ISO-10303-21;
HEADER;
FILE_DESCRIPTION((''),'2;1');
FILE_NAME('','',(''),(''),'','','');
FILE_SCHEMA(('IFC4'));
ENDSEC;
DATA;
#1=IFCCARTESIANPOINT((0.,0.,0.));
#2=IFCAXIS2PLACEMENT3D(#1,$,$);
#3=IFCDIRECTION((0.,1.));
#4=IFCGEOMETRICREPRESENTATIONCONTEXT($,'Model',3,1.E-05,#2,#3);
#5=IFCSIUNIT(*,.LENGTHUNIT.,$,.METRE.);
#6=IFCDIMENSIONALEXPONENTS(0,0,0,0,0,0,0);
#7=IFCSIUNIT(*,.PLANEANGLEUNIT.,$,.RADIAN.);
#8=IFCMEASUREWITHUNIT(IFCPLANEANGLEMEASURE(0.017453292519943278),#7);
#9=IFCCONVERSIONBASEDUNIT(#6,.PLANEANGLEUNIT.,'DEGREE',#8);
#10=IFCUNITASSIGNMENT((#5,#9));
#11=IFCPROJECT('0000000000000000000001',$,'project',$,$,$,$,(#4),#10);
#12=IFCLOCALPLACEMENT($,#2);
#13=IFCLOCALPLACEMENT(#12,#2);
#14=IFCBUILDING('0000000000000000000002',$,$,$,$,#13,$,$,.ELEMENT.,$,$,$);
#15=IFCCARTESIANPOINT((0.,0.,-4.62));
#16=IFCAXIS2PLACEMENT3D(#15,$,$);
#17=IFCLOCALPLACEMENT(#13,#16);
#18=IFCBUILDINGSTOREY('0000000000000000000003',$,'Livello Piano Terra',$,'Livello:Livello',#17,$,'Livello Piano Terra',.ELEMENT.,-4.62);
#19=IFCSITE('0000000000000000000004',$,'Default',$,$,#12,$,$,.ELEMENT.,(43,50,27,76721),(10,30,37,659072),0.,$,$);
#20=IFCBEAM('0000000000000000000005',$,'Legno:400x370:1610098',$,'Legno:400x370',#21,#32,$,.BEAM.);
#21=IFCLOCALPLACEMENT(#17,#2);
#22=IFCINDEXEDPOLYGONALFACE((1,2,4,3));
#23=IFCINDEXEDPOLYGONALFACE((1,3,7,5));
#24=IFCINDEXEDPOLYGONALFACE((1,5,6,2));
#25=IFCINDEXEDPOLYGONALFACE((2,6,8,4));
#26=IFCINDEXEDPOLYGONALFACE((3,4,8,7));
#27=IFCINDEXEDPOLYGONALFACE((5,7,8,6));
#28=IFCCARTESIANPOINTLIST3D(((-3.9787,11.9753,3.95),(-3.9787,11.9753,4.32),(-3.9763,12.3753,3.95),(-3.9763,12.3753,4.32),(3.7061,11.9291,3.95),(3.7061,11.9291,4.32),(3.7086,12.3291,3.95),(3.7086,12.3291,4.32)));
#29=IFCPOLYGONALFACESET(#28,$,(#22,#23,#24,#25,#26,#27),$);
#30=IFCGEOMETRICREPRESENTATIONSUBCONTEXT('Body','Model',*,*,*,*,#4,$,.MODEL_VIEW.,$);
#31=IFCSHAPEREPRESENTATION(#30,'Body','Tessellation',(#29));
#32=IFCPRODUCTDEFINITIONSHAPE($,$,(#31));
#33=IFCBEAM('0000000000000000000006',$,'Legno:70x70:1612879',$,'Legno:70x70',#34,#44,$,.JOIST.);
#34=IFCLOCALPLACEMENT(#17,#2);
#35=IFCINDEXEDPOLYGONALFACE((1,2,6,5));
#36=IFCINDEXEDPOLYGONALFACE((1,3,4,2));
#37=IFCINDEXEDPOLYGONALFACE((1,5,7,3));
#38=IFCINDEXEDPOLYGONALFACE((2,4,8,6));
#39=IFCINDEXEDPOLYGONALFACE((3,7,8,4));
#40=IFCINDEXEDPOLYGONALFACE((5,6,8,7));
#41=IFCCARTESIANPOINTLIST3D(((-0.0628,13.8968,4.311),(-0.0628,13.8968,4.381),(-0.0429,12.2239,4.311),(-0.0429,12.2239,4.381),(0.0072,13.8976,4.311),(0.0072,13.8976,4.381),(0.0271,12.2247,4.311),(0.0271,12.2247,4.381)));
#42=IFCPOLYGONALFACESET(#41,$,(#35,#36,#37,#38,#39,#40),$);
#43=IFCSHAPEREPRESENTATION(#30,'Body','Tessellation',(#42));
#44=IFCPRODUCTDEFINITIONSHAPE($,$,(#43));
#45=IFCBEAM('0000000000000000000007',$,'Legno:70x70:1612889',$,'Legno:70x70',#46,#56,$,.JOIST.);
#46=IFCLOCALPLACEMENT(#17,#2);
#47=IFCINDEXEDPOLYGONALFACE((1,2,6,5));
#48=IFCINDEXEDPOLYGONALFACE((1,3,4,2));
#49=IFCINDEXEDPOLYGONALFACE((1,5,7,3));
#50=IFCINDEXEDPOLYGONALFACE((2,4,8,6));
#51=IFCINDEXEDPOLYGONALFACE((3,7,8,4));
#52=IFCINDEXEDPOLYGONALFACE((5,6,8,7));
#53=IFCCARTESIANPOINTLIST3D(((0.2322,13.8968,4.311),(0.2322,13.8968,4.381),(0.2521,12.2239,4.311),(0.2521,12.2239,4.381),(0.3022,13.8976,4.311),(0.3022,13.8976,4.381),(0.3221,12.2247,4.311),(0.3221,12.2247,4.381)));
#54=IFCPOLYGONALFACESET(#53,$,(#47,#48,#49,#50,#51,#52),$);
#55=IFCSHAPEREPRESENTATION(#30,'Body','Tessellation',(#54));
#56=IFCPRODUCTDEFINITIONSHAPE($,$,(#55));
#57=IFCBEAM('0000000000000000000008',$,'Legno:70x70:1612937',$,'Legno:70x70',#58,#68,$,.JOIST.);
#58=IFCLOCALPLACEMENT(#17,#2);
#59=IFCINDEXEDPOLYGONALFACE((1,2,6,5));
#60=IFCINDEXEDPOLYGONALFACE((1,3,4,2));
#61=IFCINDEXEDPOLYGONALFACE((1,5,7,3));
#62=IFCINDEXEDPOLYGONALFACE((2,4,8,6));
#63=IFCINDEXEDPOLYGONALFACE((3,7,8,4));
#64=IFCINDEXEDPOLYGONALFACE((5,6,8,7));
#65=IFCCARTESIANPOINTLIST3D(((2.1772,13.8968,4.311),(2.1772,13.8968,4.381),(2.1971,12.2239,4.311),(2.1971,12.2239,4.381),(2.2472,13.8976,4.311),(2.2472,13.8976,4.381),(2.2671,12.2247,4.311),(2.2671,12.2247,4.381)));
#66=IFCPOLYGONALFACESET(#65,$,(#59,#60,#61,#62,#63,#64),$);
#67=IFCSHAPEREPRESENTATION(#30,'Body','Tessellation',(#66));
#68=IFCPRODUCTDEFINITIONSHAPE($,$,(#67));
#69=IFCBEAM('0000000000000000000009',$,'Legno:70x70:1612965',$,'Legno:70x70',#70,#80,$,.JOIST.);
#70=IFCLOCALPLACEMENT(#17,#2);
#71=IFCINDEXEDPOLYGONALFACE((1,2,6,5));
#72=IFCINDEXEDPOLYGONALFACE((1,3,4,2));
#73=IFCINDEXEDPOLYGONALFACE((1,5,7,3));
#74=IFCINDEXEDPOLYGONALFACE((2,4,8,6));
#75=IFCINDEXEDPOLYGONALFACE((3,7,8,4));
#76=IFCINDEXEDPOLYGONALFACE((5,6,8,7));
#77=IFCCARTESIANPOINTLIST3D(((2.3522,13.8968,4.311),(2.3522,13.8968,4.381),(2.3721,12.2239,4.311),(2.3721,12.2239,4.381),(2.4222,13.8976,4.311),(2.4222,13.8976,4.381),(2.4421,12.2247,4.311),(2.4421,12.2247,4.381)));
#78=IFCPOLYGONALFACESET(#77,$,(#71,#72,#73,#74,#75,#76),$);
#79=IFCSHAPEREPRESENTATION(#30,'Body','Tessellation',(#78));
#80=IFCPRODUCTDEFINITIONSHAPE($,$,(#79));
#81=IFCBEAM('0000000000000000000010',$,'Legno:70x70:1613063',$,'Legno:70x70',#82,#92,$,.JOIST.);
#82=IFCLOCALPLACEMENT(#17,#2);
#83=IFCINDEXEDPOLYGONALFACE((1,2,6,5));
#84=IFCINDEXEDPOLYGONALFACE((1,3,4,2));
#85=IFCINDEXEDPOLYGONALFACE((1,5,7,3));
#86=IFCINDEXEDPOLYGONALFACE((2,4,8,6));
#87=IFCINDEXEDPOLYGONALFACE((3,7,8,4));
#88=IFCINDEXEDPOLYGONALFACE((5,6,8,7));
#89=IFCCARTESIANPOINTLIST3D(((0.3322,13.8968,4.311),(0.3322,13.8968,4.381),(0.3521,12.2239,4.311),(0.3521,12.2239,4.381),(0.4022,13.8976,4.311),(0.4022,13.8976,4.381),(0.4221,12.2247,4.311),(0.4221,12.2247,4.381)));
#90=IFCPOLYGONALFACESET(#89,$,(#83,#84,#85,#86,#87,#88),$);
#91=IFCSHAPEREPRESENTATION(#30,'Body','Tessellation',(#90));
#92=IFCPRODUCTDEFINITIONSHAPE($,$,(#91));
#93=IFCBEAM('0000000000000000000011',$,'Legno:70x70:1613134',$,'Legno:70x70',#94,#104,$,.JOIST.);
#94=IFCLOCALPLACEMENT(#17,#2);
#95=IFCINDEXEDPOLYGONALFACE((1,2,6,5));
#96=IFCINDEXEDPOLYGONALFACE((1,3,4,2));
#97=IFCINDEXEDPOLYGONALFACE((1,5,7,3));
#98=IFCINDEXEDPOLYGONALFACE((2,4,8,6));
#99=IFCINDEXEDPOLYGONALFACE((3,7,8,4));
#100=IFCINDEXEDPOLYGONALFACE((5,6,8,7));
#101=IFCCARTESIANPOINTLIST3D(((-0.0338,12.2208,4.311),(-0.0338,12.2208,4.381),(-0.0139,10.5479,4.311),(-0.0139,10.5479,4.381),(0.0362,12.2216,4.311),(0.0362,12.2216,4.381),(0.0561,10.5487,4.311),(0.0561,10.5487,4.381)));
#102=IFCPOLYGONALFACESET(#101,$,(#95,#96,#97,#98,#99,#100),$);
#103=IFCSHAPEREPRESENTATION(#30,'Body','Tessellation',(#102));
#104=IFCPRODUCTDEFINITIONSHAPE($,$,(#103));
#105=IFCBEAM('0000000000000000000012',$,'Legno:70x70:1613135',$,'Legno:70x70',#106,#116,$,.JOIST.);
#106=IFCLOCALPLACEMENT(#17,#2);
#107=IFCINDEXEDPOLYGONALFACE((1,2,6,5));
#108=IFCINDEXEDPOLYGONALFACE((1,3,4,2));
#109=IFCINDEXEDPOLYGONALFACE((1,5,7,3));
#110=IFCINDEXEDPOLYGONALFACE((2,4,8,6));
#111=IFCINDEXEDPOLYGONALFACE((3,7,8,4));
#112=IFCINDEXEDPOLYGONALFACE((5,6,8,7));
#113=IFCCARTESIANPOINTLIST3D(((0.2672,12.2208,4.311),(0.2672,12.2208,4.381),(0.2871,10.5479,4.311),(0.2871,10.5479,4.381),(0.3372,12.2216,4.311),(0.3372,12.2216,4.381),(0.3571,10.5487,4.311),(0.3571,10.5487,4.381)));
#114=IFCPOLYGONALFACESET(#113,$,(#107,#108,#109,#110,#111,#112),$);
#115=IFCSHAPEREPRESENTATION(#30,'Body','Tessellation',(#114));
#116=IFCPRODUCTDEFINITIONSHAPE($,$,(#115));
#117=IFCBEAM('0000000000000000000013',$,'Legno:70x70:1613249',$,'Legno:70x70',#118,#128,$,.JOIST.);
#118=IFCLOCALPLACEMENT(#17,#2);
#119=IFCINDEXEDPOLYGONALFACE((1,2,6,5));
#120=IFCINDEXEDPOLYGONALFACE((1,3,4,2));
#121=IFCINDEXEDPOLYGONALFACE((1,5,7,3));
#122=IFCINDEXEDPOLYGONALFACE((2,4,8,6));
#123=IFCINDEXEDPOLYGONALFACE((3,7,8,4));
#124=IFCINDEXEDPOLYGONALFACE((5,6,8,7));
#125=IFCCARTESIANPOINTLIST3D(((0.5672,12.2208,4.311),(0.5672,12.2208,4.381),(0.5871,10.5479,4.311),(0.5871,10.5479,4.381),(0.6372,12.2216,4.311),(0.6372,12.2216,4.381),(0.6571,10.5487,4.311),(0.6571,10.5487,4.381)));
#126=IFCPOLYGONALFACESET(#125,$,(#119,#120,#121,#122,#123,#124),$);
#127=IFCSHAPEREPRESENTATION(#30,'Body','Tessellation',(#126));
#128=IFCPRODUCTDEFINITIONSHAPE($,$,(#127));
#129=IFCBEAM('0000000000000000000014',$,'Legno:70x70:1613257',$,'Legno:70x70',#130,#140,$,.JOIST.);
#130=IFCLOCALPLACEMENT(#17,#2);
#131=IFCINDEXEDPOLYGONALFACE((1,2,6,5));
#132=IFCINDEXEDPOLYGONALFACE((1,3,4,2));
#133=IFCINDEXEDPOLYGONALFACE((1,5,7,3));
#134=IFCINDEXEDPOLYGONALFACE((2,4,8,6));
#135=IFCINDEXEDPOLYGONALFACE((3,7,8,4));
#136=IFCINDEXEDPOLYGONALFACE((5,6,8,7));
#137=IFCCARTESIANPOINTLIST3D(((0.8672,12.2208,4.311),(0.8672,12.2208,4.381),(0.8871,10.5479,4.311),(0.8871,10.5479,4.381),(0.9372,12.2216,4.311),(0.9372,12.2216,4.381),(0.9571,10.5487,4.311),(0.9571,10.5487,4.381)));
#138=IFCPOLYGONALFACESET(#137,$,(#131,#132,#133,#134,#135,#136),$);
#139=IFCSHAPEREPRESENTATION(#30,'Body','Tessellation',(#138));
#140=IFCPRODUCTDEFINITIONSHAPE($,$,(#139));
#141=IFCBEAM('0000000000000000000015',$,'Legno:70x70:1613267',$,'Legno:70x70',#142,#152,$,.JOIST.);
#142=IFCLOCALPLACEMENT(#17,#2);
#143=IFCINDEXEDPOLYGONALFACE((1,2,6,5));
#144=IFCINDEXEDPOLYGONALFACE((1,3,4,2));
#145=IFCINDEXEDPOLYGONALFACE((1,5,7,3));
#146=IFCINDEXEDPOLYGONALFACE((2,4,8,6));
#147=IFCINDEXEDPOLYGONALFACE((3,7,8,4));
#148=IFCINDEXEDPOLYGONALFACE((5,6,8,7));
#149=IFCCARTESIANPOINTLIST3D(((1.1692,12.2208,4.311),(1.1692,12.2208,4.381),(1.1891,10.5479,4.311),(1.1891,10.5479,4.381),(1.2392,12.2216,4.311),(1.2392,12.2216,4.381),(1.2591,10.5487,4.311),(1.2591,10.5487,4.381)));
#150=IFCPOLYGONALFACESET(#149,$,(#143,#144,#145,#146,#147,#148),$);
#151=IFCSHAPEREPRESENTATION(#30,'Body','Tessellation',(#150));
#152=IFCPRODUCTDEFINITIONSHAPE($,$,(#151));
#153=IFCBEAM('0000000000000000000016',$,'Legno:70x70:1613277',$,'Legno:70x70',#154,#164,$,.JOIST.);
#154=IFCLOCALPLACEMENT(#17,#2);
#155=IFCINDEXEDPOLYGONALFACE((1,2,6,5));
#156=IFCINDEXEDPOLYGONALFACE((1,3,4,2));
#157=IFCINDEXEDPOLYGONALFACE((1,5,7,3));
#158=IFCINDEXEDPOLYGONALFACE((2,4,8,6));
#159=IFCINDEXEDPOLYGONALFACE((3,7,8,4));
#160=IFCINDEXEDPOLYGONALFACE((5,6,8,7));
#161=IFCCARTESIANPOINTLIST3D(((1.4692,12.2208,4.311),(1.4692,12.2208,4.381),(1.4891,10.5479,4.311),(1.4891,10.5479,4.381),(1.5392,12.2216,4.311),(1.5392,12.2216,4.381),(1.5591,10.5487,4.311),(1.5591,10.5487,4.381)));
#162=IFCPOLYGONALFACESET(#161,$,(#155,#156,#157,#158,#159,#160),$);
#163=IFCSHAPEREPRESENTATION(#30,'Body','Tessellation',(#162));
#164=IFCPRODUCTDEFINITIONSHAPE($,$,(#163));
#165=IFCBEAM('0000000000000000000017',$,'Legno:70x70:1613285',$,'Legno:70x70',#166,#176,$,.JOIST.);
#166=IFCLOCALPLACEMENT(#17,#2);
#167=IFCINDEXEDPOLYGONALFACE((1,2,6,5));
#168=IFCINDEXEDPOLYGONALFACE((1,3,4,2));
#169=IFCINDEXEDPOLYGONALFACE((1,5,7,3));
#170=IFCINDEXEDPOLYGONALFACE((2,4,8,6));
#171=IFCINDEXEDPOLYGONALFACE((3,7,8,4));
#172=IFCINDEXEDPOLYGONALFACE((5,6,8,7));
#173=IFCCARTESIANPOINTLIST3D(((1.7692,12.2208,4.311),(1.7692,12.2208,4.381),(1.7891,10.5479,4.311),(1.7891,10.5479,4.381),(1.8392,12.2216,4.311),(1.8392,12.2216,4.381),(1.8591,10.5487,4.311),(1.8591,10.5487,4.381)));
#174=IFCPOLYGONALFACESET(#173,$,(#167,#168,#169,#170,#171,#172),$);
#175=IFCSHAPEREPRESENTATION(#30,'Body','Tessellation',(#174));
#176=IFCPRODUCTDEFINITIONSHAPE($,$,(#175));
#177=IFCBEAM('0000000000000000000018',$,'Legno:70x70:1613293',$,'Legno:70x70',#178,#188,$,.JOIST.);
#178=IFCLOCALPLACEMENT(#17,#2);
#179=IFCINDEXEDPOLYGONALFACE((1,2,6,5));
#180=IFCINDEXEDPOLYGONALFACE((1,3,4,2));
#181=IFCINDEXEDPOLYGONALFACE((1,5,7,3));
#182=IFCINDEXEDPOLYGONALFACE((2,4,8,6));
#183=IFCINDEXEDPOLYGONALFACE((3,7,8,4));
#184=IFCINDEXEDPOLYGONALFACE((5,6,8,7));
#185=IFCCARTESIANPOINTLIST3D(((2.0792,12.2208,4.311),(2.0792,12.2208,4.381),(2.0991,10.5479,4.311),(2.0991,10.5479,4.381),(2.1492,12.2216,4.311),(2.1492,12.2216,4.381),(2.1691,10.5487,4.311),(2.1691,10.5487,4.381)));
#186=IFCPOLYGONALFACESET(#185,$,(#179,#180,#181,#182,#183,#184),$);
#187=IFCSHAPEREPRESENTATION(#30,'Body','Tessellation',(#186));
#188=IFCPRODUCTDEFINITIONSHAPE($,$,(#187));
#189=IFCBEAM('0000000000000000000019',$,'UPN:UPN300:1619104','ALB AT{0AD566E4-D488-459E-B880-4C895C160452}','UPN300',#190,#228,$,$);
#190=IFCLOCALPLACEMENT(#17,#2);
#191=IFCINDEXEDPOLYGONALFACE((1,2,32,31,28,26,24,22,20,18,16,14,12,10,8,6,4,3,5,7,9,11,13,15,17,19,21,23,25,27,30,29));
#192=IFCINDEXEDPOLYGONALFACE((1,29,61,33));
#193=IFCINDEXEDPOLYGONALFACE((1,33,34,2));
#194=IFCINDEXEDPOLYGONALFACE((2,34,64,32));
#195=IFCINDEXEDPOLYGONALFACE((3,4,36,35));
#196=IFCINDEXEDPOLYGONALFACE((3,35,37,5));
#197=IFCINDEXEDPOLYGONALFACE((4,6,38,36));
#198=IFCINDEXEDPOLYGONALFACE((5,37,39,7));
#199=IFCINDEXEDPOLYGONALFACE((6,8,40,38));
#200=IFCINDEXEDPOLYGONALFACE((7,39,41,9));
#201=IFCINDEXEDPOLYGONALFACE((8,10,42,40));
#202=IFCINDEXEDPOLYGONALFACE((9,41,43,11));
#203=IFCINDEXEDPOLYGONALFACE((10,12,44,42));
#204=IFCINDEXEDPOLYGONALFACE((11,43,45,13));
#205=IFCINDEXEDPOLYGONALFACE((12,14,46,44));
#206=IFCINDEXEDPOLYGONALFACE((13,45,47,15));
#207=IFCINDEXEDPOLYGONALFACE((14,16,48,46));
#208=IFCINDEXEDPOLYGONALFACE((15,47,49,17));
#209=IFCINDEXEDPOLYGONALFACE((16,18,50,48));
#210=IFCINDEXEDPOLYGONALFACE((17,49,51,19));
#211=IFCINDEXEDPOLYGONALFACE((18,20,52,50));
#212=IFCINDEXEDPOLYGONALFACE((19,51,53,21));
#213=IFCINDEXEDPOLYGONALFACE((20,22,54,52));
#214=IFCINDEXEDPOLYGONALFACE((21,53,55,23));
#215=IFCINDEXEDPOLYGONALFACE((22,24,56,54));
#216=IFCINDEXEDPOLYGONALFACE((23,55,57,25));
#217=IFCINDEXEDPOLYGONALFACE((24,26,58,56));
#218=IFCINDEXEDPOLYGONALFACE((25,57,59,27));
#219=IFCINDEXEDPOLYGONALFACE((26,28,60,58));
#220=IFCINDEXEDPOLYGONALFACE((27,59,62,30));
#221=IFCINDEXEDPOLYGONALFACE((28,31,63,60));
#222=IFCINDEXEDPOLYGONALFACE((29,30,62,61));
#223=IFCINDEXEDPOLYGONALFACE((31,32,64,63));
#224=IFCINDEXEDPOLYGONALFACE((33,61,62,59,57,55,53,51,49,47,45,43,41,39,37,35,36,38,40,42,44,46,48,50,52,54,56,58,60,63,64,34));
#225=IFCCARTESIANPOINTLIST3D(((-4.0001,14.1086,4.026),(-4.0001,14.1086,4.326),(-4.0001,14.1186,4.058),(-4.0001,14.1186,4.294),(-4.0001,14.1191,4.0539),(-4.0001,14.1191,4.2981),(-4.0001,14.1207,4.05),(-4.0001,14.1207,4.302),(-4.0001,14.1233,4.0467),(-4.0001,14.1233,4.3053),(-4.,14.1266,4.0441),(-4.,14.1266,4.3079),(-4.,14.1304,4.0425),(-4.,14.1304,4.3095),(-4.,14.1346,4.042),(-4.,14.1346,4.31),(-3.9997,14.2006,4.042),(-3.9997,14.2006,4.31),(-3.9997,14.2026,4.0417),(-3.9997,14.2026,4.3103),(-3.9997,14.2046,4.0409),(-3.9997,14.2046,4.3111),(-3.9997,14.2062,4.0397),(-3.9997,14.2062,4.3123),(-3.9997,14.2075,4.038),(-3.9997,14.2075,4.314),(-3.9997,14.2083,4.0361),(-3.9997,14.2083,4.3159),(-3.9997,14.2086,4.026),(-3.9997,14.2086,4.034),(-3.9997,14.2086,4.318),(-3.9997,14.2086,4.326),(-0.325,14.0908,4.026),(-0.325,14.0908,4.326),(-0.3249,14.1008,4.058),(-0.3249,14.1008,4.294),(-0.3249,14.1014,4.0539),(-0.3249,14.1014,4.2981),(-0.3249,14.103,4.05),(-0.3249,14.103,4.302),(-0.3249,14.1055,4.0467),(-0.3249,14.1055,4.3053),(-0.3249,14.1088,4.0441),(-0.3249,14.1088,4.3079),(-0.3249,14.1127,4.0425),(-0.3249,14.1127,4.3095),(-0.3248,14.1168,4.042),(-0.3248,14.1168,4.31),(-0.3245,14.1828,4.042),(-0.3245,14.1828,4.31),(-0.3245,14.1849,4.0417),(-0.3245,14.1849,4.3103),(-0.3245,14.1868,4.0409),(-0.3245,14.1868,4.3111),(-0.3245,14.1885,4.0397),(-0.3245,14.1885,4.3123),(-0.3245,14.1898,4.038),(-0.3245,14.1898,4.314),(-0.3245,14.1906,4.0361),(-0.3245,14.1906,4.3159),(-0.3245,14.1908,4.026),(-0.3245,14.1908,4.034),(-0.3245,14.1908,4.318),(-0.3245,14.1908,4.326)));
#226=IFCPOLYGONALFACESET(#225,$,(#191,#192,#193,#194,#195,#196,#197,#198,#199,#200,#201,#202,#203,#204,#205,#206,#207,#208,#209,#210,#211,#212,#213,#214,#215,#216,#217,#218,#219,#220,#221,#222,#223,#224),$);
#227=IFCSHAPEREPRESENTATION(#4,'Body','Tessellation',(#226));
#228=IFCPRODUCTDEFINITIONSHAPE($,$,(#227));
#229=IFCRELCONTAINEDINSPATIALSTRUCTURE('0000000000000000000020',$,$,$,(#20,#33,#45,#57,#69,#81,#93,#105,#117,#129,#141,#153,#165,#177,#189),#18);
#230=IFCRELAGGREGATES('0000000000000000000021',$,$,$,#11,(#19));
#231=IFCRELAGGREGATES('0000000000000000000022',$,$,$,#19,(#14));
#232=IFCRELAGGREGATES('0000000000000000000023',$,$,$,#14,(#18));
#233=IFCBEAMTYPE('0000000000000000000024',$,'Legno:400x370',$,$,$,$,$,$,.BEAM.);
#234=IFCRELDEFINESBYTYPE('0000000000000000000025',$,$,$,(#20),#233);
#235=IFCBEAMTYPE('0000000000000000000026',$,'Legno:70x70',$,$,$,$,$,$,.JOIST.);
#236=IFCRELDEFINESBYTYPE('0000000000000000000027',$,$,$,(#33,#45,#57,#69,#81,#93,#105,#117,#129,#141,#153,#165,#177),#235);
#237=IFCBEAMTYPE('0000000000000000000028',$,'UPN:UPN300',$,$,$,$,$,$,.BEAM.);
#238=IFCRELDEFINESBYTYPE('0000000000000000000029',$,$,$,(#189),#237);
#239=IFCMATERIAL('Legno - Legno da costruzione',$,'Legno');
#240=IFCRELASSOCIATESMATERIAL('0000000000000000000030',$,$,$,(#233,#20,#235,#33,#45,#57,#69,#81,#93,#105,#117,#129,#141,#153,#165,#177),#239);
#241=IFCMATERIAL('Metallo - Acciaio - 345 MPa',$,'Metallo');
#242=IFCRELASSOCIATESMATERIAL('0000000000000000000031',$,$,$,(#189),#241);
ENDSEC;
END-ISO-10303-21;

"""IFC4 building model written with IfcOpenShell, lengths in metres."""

from ifc_helpers import new_model, entity, si_unit, converted_unit, direction, frame, frame_2d, origin, place, context, subcontext, project, spatial, indexed_curve, u_section, outline, extrude, clip, halfspace, source, transform, mapped, material, type_object, type_shapes, element, save


model = new_model("IFC4")

# Units and contexts
model_context = context("Model", 3, precision=1e-05, world=origin(), true_north=direction((0.0, 1.0)))
body_context = subcontext(model_context, "Body", "Model", "MODEL_VIEW")
ifc_project = project(units=[si_unit("LENGTHUNIT", "METRE"), converted_unit("PLANEANGLEUNIT", "DEGREE", entity("IfcPlaneAngleMeasure", 0.017453292519943278), si_unit("PLANEANGLEUNIT", "RADIAN"), dimensions=[0, 0, 0, 0, 0, 0, 0])], contexts=[model_context])

# Site, building, storey
site_placement = place(None, origin())
site = spatial("IfcSite", under=ifc_project, at=site_placement, Name="Default", CompositionType="ELEMENT", RefLatitude=(43, 50, 27, 76721), RefLongitude=(10, 30, 37, 659072), RefElevation=0.0)
building_placement = place(site_placement, origin())
building = spatial("IfcBuilding", under=site, at=building_placement, CompositionType="ELEMENT")
storey_placement = place(building_placement, frame((0.0, 0.0, -4.62)))
storey = spatial("IfcBuildingStorey", under=building, at=storey_placement, Name="Livello Piano Terra", ObjectType="Livello:Livello", LongName="Livello Piano Terra", CompositionType="ELEMENT", Elevation=-4.62)

# Beams
ifc_material_1 = material(Name="Legno - Legno da costruzione", Category="Legno")
beam_type_1 = type_object("IfcBeamType", Name="Legno:400x370", PredefinedType="BEAM", material=ifc_material_1)
shared_shape_1 = source(origin(), body_context, "Body", "SweptSolid", [
    extrude(outline(indexed_curve([(-3.8425, -0.2), (3.8425, -0.2), (3.8425, 0.2), (-3.8425, 0.2), (-3.8425, -0.2)], self_intersect=False)), frame((0.0, 0.0, -0.185), z_axis=(0.0, 0.0, 1.0), x_axis=(-1.0, 0.0, 0.0)), (0.0, 0.0, 1.0), 0.37),
])
type_shapes(beam_type_1, [shared_shape_1])
beam_1_placement = place(storey_placement, frame((-0.1351, 12.1522, 4.135), z_axis=(0.0, 0.0, 1.0), x_axis=(0.999982, -0.006016, 0.0)))
element("IfcBeam", 1, at=beam_1_placement, inside=storey, type_object=beam_type_1, material=ifc_material_1, Name="Legno:400x370:1610098", ObjectType="Legno:400x370", PredefinedType="BEAM", context=body_context, shape_type="MappedRepresentation", body=[
    mapped(shared_shape_1, transform((0.0, 0.0, 0.0), scale=1.0)),
])
beam_type_2 = type_object("IfcBeamType", Name="Legno:70x70", PredefinedType="JOIST", material=ifc_material_1)
shared_shape_2 = source(origin(), body_context, "Body", "SweptSolid", [
    extrude(outline(indexed_curve([(-0.8365, -0.035), (0.8365, -0.035), (0.8365, 0.035), (-0.8365, 0.035), (-0.8365, -0.035)], self_intersect=False)), frame((0.0, 0.0, -0.035), z_axis=(0.0, 0.0, 1.0), x_axis=(-1.0, 0.0, 0.0)), (0.0, 0.0, 1.0), 0.07),
])
type_shapes(beam_type_2, [shared_shape_2])
for number, where, z_axis, x_axis, name in (
    (2, (-0.0178, 13.0608, 4.346), (0.0, 0.0, 1.0), (0.011914, -0.999929, 0.0), "Legno:70x70:1612879"),
    (3, (0.2772, 13.0608, 4.346), (0.0, 0.0, 1.0), (0.011914, -0.999929, 0.0), "Legno:70x70:1612889"),
    (4, (2.2222, 13.0608, 4.346), (0.0, 0.0, 1.0), (0.011914, -0.999929, 0.0), "Legno:70x70:1612937"),
    (5, (2.3972, 13.0608, 4.346), (0.0, 0.0, 1.0), (0.011914, -0.999929, 0.0), "Legno:70x70:1612965"),
    (6, (0.3772, 13.0608, 4.346), (0.0, 0.0, 1.0), (0.011914, -0.999929, 0.0), "Legno:70x70:1613063"),
    (7, (0.0112, 11.3848, 4.346), (0.0, 0.0, 1.0), (0.011914, -0.999929, 0.0), "Legno:70x70:1613134"),
    (8, (0.3122, 11.3848, 4.346), (0.0, 0.0, 1.0), (0.011914, -0.999929, 0.0), "Legno:70x70:1613135"),
    (9, (0.6122, 11.3848, 4.346), (0.0, 0.0, 1.0), (0.011914, -0.999929, 0.0), "Legno:70x70:1613249"),
    (10, (0.9122, 11.3848, 4.346), (0.0, 0.0, 1.0), (0.011914, -0.999929, 0.0), "Legno:70x70:1613257"),
    (11, (1.2142, 11.3848, 4.346), (0.0, 0.0, 1.0), (0.011914, -0.999929, 0.0), "Legno:70x70:1613267"),
    (12, (1.5142, 11.3848, 4.346), (0.0, 0.0, 1.0), (0.011914, -0.999929, 0.0), "Legno:70x70:1613277"),
    (13, (1.8142, 11.3848, 4.346), (0.0, 0.0, 1.0), (0.011914, -0.999929, 0.0), "Legno:70x70:1613285"),
    (14, (2.1242, 11.3848, 4.346), (0.0, 0.0, 1.0), (0.011914, -0.999929, 0.0), "Legno:70x70:1613293"),
):
    element("IfcBeam", number, at=place(storey_placement, frame(where, z_axis=z_axis, x_axis=x_axis)), inside=storey, type_object=beam_type_2, material=ifc_material_1, Name=name, ObjectType="Legno:70x70", PredefinedType="JOIST", context=body_context, shape_type="MappedRepresentation", body=[
        mapped(shared_shape_2, transform((0.0, 0.0, 0.0), scale=1.0)),
    ])
ifc_material_2 = material(Name="Metallo - Acciaio - 345 MPa", Category="Metallo")
beam_type_3 = type_object("IfcBeamType", Name="UPN:UPN300", PredefinedType="BEAM")
beam_2_placement = place(storey_placement, frame((0.1383, 14.1156, 4.176), z_axis=(0.999988, -0.00483, 0.0), x_axis=(0.00483, 0.999988, 0.0)))
element("IfcBeam", 15, at=beam_2_placement, inside=storey, type_object=beam_type_3, material=ifc_material_2, Name="UPN:UPN300:1619104", Description="ALB AT{0AD566E4-D488-459E-B880-4C895C160452}", ObjectType="UPN300", context=model_context, shape_type="Clipping", body=[
    clip(extrude(u_section(Depth=0.3, FlangeWidth=0.1, WebThickness=0.01, FlangeThickness=0.016, FilletRadius=0.016, EdgeRadius=0.008, FlangeSlope=0.00457, at=frame_2d((0.023, 0.0))), origin(), (0.0, 0.0, -1.0), 4.1383), halfspace(frame((-14.1161, 0.444, -0.4631), z_axis=(0.0, 0.0, -1.0), x_axis=(-1.0, 0.0, 0.0)), True)),
])

save(model, "model.ifc")
